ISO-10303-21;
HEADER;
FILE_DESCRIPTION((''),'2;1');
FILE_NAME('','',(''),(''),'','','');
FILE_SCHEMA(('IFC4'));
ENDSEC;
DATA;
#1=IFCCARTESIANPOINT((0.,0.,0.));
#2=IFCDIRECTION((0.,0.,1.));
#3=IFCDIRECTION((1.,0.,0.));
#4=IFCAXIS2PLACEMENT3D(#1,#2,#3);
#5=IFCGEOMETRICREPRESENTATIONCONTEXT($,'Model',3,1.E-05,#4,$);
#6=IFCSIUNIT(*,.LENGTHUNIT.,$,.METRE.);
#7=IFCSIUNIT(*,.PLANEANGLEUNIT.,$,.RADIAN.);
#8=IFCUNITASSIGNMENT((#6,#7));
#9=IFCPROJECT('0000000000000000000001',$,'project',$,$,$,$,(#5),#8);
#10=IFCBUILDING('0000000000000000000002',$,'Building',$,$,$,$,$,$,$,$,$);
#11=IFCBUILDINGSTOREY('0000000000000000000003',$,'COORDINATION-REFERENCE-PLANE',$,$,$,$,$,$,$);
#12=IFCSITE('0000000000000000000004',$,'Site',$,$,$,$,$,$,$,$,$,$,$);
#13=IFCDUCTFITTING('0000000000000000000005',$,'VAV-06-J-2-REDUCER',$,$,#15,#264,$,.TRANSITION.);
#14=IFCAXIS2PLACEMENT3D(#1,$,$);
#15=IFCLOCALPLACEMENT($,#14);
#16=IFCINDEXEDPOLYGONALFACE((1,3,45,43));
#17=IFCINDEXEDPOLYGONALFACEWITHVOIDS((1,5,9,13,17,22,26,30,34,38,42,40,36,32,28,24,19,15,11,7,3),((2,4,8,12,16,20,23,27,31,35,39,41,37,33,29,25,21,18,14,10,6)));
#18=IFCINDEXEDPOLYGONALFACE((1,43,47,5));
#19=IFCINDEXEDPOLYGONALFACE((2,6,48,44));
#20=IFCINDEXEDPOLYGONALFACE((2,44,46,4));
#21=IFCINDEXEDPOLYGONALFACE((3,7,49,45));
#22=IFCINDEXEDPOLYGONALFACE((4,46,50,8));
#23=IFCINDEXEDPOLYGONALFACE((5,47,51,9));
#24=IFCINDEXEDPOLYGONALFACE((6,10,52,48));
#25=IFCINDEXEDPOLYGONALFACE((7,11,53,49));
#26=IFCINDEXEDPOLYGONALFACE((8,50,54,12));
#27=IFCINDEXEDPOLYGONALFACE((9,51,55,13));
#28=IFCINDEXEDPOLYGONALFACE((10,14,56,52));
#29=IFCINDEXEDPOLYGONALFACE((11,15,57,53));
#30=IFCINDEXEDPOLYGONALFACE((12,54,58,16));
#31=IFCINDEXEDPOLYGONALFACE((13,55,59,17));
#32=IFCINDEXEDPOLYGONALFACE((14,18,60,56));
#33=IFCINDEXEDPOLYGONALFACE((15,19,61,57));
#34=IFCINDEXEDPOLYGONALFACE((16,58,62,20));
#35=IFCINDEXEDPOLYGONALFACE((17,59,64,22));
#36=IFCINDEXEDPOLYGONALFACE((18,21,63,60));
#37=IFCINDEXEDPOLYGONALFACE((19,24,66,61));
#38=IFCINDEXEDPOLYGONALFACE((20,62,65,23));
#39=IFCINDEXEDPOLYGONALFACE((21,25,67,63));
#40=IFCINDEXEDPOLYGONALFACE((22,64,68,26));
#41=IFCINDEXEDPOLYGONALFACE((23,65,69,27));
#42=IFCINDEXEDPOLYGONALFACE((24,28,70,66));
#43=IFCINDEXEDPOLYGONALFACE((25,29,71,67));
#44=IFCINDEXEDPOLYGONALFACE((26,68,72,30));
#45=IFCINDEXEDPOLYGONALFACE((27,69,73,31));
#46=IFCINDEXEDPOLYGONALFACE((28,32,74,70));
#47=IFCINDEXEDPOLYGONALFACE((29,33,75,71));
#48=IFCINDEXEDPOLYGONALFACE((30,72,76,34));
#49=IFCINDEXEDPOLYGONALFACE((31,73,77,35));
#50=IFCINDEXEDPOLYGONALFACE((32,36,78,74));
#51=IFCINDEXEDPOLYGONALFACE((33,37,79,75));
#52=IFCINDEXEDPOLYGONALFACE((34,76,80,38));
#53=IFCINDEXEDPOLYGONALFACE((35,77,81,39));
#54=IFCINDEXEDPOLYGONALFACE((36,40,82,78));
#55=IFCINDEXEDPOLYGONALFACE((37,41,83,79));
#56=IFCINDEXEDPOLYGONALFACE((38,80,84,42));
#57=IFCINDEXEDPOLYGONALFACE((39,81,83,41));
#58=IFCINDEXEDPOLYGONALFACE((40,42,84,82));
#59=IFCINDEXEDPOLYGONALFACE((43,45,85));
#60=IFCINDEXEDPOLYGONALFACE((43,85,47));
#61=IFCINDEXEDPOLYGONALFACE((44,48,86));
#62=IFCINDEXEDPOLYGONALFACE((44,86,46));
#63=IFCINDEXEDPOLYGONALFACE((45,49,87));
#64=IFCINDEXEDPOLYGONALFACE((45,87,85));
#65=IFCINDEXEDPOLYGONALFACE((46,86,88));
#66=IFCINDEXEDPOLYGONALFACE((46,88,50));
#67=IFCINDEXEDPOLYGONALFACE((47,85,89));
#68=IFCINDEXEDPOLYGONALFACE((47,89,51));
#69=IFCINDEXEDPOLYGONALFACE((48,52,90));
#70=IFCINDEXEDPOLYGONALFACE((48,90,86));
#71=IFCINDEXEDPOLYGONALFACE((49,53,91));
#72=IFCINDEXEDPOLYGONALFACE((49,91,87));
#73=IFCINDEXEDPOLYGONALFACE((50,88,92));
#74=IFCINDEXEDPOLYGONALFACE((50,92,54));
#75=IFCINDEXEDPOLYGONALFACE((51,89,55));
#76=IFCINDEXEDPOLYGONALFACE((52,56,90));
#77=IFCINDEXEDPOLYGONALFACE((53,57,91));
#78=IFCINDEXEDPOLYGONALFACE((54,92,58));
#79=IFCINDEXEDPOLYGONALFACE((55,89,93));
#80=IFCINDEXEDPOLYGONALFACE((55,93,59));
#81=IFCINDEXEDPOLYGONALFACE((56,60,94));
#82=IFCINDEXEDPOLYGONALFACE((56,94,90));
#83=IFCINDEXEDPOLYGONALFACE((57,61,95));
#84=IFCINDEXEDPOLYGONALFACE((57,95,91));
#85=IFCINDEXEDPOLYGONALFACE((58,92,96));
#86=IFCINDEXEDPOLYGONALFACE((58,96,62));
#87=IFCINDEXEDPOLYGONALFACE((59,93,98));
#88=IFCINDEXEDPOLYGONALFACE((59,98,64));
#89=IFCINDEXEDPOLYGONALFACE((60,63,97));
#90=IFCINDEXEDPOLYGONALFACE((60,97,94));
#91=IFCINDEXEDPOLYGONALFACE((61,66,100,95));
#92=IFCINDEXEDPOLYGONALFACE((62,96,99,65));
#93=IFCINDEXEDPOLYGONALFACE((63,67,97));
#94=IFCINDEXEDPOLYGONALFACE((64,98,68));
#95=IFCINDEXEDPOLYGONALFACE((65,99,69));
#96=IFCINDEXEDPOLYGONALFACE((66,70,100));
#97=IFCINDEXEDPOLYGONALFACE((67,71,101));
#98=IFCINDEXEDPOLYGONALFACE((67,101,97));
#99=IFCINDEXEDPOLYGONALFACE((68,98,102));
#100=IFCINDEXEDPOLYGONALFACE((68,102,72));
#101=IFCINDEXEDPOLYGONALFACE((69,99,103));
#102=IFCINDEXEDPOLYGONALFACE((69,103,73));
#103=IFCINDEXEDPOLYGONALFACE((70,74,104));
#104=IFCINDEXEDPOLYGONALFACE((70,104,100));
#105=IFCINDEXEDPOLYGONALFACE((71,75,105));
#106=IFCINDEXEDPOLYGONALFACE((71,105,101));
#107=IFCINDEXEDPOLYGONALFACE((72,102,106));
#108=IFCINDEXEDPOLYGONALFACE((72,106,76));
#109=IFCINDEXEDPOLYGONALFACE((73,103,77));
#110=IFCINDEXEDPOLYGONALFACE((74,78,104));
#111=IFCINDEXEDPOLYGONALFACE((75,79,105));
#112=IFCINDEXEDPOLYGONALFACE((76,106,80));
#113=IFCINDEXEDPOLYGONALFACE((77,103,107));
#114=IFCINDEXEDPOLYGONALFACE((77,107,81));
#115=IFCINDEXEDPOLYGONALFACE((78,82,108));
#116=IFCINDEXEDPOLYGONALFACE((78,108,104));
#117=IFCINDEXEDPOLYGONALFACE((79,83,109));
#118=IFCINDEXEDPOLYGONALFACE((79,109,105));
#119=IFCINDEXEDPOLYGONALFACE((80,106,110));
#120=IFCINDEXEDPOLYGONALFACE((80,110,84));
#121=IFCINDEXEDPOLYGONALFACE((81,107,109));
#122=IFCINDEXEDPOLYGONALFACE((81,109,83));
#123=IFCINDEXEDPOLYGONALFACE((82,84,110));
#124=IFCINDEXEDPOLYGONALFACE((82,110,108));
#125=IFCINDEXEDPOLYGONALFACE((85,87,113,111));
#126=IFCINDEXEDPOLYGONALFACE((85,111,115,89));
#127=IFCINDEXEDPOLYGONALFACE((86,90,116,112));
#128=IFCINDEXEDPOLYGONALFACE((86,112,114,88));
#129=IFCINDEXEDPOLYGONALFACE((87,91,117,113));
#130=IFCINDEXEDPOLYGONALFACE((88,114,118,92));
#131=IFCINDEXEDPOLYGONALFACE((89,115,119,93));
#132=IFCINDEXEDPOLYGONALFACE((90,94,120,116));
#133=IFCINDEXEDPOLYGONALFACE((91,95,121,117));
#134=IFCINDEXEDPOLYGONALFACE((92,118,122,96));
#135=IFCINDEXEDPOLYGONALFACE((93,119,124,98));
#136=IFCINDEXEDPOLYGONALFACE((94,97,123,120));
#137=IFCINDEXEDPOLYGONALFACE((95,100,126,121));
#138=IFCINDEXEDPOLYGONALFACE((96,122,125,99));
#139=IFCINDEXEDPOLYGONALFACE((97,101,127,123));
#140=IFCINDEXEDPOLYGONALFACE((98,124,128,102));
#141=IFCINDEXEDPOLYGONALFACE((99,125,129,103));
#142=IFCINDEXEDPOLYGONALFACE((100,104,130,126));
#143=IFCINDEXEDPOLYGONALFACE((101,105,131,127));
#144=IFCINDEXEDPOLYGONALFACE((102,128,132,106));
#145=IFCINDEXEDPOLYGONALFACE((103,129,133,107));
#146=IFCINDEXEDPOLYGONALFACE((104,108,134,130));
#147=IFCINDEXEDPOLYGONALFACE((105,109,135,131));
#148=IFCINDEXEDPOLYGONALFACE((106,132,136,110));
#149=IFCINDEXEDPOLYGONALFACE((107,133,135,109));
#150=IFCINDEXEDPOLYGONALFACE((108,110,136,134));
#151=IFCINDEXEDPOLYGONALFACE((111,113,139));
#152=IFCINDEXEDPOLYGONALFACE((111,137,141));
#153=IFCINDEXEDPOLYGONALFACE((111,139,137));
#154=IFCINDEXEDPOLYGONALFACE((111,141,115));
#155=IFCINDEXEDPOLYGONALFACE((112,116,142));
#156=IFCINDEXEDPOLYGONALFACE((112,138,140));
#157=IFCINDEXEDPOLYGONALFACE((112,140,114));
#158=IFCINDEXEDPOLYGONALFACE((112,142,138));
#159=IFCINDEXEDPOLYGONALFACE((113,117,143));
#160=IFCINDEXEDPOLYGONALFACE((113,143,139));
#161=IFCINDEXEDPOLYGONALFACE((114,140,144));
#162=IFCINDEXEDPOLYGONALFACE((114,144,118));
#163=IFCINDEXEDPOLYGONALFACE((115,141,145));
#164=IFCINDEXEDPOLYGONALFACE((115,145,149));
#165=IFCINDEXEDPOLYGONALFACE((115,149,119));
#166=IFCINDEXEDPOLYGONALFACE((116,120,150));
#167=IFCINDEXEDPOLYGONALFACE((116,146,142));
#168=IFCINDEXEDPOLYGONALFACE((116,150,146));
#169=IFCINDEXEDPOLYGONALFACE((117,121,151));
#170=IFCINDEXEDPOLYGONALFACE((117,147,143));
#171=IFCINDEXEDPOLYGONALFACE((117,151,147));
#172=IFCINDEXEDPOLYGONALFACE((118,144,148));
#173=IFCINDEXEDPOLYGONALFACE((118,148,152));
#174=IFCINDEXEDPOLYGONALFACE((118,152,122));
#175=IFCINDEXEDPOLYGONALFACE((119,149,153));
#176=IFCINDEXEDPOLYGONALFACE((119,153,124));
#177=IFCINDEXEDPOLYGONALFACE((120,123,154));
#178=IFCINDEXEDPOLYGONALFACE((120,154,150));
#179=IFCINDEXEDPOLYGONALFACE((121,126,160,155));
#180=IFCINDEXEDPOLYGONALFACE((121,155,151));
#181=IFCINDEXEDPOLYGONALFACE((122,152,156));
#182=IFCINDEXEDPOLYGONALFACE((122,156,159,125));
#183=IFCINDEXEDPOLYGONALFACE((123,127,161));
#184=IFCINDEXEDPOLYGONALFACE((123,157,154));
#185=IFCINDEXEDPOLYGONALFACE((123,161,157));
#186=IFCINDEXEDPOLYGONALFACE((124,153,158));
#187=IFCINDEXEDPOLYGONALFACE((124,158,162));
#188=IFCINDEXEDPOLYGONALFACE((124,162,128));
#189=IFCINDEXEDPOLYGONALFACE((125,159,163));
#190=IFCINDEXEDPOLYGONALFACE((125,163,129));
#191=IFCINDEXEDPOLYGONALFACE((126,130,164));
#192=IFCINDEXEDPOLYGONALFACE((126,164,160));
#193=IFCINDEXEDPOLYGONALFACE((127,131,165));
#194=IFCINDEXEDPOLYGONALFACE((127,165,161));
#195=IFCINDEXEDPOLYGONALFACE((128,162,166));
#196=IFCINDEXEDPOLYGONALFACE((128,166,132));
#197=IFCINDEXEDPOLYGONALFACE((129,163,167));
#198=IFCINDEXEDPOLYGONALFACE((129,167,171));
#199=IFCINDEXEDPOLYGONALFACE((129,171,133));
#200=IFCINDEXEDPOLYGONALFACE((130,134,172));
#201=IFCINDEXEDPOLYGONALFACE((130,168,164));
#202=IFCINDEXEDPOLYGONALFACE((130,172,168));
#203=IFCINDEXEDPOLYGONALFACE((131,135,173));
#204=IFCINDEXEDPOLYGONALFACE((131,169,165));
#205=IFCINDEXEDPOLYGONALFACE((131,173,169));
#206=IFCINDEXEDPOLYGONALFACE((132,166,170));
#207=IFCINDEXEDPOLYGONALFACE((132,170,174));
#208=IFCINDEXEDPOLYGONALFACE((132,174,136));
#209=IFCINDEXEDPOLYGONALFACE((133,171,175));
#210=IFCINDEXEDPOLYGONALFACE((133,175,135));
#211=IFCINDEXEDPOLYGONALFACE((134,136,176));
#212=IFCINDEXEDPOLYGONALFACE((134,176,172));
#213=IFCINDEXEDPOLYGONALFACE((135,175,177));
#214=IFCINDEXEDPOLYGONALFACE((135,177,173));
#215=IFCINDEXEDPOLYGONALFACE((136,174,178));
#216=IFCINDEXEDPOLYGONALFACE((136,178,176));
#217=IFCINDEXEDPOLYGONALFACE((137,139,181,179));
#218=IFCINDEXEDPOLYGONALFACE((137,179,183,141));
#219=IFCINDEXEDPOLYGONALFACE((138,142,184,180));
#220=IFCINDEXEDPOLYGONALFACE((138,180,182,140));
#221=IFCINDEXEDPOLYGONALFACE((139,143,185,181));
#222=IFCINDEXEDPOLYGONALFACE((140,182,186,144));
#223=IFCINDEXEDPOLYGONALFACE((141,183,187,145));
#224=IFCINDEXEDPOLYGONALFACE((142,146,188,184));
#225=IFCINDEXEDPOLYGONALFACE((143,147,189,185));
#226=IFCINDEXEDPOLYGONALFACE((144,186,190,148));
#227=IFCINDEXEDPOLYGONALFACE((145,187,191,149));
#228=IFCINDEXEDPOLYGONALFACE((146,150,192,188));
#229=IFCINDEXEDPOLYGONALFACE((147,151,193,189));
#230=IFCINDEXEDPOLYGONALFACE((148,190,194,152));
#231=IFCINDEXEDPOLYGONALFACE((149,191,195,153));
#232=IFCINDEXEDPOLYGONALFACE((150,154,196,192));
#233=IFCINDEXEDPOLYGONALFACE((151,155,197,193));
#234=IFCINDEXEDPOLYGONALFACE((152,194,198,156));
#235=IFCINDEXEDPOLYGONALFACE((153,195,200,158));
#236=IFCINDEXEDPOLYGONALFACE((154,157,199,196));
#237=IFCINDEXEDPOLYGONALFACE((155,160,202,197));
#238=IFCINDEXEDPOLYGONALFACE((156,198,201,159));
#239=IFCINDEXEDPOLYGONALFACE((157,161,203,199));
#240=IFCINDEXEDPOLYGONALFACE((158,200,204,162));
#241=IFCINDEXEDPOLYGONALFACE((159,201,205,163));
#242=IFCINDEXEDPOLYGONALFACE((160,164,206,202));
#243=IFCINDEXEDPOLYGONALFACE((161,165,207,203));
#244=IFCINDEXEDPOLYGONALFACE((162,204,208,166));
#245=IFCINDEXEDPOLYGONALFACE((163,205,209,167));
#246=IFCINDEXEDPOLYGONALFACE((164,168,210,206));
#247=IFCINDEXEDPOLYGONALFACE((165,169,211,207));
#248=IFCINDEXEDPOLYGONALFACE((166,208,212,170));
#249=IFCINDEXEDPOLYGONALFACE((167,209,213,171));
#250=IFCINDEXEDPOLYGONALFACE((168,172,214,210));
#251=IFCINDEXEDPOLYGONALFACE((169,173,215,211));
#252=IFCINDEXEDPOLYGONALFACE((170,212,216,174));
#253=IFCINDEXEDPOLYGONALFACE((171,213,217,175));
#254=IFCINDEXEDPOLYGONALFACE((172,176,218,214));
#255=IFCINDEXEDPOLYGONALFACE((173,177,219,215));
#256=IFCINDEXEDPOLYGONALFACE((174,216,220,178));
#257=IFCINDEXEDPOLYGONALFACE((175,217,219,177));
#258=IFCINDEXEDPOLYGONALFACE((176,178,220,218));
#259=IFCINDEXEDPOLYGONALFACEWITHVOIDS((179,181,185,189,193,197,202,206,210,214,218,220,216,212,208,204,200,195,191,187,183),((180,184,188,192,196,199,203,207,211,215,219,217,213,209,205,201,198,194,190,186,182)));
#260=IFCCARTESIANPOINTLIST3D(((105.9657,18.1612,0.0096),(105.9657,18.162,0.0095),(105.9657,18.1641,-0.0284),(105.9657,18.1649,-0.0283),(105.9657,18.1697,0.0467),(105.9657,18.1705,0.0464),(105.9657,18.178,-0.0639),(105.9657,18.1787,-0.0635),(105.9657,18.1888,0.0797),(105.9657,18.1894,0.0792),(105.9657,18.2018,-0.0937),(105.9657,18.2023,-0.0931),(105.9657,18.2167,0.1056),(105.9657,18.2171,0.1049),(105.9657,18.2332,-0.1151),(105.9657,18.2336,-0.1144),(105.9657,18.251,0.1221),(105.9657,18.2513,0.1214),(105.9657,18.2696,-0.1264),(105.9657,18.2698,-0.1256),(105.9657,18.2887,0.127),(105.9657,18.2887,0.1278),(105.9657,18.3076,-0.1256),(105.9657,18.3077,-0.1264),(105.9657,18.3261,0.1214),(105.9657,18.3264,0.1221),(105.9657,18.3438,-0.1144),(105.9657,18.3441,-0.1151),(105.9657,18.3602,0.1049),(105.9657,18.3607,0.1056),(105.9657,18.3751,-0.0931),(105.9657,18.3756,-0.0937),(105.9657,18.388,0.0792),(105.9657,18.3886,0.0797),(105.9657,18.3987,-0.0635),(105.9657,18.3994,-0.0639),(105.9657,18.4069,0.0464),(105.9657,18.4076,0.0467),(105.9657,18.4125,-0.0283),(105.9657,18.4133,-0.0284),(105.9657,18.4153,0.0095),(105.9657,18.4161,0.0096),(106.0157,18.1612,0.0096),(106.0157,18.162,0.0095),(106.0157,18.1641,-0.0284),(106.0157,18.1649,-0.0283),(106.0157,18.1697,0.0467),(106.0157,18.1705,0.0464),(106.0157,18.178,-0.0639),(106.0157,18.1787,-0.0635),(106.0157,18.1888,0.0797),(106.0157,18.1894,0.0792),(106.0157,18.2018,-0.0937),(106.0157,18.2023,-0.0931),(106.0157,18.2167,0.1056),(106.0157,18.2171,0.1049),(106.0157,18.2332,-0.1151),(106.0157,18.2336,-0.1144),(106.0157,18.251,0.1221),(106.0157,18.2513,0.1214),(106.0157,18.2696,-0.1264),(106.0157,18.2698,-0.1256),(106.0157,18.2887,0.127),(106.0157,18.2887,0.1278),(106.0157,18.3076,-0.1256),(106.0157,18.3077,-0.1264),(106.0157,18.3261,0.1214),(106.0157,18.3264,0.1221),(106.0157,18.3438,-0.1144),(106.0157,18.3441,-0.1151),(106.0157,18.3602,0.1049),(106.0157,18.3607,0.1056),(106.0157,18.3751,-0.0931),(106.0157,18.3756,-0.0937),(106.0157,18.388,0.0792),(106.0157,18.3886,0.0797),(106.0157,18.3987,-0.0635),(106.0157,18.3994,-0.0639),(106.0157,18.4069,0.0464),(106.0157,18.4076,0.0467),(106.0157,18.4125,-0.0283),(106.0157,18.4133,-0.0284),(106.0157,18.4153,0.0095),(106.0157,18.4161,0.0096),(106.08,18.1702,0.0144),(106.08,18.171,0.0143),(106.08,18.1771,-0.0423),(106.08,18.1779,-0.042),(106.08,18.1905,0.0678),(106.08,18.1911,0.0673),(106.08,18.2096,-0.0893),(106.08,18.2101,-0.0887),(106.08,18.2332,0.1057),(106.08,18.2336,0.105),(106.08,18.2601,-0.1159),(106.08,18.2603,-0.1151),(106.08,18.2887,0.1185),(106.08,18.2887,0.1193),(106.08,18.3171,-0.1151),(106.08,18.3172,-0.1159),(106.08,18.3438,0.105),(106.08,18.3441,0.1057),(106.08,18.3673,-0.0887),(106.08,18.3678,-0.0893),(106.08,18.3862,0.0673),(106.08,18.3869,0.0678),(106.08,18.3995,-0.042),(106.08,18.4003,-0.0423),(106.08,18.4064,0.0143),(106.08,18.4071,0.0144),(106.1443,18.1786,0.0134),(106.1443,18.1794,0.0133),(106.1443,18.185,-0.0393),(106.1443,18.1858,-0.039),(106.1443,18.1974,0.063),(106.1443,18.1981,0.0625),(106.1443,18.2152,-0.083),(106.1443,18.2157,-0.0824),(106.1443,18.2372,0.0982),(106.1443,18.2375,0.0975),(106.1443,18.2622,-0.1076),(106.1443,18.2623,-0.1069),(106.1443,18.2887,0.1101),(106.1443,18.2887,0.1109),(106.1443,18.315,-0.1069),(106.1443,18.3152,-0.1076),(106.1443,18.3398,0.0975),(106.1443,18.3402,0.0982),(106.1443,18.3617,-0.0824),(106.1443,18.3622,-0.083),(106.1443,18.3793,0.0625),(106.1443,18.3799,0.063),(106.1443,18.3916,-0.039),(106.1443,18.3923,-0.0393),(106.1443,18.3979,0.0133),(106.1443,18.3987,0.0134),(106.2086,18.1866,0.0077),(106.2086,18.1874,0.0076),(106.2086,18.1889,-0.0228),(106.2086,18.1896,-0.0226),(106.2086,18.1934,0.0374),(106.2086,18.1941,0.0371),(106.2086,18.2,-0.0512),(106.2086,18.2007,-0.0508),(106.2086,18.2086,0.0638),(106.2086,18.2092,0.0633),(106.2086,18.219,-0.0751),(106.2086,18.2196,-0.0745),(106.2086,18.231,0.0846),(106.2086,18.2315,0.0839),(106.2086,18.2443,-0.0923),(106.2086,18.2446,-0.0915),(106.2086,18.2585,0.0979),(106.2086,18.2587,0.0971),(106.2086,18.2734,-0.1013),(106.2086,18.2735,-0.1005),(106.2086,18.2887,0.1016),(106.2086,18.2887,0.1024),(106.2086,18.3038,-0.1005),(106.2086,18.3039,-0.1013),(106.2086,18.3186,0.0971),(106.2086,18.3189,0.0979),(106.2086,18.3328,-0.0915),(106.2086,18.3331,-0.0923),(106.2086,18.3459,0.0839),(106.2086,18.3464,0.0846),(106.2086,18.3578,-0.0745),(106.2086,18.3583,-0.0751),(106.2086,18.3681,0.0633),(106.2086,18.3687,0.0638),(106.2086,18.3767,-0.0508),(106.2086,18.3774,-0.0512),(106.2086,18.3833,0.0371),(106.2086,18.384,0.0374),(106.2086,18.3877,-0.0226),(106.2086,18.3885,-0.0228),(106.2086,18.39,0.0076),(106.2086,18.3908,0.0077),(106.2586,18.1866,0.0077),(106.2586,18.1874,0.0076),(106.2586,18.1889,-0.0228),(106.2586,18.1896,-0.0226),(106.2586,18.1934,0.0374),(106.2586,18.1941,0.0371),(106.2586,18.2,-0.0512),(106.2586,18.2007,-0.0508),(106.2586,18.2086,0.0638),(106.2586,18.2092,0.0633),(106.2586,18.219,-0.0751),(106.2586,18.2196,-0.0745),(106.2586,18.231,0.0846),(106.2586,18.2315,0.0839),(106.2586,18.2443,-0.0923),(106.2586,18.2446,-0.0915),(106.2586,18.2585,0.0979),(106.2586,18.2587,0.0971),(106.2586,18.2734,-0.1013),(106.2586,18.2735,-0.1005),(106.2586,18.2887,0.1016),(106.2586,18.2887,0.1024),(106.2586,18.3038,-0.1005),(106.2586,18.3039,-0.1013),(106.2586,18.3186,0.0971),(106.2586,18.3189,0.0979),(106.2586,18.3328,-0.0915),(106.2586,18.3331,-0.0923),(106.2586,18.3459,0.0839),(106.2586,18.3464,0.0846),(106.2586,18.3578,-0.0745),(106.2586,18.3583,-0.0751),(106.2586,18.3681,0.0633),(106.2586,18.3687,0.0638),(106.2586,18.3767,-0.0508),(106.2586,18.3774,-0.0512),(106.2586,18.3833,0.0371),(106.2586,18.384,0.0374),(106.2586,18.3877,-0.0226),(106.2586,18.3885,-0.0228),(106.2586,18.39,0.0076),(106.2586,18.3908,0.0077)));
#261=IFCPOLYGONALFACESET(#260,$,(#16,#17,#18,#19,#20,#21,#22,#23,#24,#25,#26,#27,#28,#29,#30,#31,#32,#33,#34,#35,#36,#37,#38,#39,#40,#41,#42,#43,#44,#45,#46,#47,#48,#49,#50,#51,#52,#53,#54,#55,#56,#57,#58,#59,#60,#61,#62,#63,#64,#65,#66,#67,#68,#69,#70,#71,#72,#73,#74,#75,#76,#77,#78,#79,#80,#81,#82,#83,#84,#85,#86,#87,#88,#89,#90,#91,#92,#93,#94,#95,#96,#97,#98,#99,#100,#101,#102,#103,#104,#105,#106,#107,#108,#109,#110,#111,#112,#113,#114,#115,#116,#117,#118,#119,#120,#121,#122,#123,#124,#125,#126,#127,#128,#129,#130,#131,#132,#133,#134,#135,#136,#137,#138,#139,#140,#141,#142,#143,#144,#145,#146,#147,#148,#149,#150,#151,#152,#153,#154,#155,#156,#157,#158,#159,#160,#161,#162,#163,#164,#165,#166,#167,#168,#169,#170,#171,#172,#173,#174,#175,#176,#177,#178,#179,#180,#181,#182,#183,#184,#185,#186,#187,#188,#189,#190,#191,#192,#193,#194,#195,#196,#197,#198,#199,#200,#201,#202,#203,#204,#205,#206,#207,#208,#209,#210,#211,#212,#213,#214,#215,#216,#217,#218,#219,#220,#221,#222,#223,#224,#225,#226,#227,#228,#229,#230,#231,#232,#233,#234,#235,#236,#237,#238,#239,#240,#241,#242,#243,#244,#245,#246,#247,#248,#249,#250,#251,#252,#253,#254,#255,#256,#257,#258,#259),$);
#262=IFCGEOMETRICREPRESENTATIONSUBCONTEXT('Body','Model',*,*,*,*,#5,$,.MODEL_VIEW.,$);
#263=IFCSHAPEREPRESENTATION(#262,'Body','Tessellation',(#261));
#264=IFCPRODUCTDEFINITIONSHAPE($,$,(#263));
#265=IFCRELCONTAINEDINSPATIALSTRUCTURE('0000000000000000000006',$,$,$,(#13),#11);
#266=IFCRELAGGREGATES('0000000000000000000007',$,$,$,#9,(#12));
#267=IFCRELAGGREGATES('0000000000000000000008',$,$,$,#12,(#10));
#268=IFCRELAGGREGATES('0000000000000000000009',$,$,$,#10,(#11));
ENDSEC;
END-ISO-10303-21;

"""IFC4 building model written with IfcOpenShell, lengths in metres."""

from ifc_helpers import new_model, entity, si_unit, frame, origin_with_axes, place, context, subcontext, project, spatial, element, save


model = new_model("IFC4")

# Units and contexts
model_context_1 = context("Model", 3, precision=1e-05, world=origin_with_axes())
body_context_1 = subcontext(model_context_1, "Body", "Model", "MODEL_VIEW")
ifc_project = project(units=[si_unit("LENGTHUNIT", "METRE"), si_unit("PLANEANGLEUNIT", "RADIAN")], contexts=[model_context_1])

# Site, building, storey
site = spatial("IfcSite", under=ifc_project, Name="Site")
building = spatial("IfcBuilding", under=site, Name="Building")
storey = spatial("IfcBuildingStorey", under=building, Name="COORDINATION-REFERENCE-PLANE")

# Duct fitting
for number, where, z_axis, x_axis, name in (
    (1, (105.9657, 18.2887, 0.0), (0.0, 1.0, 0.0), (0.0, 0.0, 1.0), "VAV-06-J-2-REDUCER"),
):
    element("IfcDuctFitting", number, at=place(None, frame(where, z_axis=z_axis, x_axis=x_axis)), inside=storey, Name=name, PredefinedType="TRANSITION", context=body_context_1, shape_type="SweptSolid", body=[
        entity("IfcRevolvedAreaSolid", entity("IfcArbitraryClosedProfileDef", "AREA", None, entity("IfcPolyline", [entity("IfcCartesianPoint", [0.1278, 0.0]), entity("IfcCartesianPoint", [0.1278, 0.05]), entity("IfcCartesianPoint", [0.1024, 0.2429]), entity("IfcCartesianPoint", [0.1024, 0.2929]), entity("IfcCartesianPoint", [0.1016, 0.2929]), entity("IfcCartesianPoint", [0.1016, 0.2429]), entity("IfcCartesianPoint", [0.127, 0.05]), entity("IfcCartesianPoint", [0.127, 0.0]), entity("IfcCartesianPoint", [0.1278, 0.0])])), entity("IfcAxis2Placement3D", entity("IfcCartesianPoint", [0.0, 0.0, 0.0])), entity("IfcAxis1Placement", entity("IfcCartesianPoint", [0.0, 0.0, 0.0]), entity("IfcDirection", [0.0, 1.0, 0.0])), 6.283185),
    ])

save(model, "model.ifc")
